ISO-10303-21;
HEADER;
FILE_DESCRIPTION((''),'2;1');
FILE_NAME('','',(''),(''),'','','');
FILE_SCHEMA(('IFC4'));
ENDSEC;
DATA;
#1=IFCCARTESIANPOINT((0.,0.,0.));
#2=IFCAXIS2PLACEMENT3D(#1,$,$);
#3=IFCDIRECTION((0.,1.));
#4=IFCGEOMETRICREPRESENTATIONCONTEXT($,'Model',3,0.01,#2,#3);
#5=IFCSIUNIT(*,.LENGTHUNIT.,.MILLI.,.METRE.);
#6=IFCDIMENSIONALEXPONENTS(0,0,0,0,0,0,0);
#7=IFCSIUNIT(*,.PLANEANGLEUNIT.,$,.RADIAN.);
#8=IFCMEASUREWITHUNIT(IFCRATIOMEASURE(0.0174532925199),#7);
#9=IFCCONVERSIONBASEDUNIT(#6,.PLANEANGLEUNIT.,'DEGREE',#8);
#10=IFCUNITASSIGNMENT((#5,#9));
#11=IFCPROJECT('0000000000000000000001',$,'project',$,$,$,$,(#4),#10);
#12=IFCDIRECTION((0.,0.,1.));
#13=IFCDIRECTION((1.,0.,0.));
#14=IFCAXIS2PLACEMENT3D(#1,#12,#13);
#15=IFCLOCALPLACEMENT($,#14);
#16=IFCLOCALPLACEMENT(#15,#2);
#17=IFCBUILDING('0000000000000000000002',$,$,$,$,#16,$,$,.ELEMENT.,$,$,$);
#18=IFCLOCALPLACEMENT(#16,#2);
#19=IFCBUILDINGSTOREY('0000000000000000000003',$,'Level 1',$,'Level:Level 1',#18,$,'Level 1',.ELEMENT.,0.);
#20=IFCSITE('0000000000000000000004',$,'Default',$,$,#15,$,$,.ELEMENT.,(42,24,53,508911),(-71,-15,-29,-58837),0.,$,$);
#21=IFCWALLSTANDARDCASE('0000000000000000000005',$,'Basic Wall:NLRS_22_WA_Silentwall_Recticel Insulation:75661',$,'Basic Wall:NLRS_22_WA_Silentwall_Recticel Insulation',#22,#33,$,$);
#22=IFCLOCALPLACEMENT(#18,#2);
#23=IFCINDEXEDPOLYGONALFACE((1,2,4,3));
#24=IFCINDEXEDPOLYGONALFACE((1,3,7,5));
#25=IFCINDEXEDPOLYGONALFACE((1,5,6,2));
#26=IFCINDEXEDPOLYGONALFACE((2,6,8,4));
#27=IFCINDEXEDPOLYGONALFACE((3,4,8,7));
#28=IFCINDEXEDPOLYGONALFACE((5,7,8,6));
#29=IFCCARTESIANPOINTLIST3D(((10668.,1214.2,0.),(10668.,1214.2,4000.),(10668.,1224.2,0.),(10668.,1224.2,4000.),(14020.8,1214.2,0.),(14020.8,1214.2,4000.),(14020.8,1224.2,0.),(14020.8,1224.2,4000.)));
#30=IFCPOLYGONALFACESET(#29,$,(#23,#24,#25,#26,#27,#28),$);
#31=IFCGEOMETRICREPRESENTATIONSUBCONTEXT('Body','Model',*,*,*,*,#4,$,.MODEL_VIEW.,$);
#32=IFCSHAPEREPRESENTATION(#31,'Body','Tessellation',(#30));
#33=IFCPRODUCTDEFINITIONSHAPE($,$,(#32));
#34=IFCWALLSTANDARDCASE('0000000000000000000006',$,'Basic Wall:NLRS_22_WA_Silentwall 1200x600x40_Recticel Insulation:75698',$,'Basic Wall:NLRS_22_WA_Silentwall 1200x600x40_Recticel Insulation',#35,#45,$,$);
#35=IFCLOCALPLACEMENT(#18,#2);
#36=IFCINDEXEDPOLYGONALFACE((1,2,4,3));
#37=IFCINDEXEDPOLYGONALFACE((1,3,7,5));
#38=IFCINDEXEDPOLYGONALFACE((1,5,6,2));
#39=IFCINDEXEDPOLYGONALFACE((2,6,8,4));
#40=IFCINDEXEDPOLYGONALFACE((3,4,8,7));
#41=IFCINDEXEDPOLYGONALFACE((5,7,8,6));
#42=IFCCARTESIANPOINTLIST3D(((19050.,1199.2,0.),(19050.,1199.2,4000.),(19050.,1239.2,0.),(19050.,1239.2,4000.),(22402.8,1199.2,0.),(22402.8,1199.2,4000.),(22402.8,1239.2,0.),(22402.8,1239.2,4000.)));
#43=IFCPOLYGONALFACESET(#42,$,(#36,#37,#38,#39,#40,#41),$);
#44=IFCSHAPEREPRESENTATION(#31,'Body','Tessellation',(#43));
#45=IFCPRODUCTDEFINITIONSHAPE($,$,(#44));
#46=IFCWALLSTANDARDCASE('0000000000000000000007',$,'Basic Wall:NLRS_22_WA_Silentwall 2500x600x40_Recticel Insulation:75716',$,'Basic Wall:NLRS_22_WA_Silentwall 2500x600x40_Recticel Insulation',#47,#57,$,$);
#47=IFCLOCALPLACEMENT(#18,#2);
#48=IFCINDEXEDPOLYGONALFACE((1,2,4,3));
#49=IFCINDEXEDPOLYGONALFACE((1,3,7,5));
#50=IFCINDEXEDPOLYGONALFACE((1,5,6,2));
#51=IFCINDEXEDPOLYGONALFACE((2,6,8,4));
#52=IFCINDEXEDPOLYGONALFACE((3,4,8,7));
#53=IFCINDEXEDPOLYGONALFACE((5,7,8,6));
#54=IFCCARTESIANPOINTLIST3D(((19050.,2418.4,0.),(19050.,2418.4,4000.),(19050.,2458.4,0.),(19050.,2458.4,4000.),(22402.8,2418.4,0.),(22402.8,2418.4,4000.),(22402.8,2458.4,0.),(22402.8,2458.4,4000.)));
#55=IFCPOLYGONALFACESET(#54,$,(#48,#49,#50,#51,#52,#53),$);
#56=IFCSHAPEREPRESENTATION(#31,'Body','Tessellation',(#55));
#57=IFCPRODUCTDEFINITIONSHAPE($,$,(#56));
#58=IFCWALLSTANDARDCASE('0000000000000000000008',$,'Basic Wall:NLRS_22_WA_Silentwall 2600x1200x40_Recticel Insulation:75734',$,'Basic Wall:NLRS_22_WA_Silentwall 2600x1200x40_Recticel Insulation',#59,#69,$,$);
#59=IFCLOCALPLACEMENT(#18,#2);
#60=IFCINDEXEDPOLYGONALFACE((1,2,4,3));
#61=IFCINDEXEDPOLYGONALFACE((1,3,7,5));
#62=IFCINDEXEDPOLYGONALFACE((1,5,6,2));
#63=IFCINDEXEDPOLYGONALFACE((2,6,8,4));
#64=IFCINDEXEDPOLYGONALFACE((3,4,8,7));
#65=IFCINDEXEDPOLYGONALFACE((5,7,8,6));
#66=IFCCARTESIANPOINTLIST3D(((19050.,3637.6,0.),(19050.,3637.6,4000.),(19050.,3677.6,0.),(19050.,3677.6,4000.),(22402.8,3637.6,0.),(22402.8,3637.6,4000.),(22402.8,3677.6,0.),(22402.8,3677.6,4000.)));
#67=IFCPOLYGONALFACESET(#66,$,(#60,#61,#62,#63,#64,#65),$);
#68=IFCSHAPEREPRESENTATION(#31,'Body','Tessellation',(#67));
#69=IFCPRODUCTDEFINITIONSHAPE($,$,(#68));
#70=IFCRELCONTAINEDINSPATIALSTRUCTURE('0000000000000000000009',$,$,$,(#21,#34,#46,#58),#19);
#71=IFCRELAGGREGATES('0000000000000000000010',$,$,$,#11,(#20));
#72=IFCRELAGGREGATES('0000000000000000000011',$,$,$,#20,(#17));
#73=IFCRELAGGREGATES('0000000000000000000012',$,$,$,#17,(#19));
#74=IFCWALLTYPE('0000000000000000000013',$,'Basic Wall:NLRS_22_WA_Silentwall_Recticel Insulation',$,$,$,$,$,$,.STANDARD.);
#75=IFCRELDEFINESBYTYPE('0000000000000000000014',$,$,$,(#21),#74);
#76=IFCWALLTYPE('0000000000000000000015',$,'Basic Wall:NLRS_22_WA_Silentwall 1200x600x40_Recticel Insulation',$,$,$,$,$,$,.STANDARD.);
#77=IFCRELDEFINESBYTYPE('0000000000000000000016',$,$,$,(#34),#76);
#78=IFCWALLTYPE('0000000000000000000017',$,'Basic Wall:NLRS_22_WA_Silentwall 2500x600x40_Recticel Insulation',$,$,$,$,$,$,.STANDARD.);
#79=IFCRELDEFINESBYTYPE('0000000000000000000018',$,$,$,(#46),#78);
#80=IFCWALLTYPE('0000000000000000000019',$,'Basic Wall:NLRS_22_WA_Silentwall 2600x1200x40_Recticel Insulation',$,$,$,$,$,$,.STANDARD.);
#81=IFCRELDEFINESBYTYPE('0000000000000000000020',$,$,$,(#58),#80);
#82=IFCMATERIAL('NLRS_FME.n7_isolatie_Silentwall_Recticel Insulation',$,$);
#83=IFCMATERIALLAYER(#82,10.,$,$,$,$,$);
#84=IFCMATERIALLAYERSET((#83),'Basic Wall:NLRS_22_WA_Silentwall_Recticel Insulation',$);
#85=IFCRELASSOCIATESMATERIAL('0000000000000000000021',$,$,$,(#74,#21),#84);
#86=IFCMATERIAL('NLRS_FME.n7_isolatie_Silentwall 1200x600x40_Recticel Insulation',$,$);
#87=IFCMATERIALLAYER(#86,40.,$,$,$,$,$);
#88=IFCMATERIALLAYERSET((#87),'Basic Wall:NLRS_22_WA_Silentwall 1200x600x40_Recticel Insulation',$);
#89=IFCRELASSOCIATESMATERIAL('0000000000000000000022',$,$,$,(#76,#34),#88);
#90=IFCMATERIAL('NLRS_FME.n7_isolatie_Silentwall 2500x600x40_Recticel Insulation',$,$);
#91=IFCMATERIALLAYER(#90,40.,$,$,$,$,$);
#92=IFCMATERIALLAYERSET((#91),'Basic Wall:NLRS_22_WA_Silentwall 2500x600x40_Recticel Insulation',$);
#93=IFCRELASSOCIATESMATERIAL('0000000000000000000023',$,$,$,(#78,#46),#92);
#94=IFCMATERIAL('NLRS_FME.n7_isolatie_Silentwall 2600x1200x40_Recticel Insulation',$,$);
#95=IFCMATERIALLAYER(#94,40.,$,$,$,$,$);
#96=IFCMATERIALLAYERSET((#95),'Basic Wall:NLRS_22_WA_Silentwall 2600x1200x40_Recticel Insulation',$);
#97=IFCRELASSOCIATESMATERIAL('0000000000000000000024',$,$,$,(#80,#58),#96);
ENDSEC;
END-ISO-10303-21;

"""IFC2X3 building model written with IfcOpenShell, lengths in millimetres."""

from ifc_helpers import new_model, entity, si_unit, converted_unit, direction, frame, origin, origin_with_axes, origin_2d_with_axis, place, context, subcontext, project, spatial, rectangle, extrude, material, layer, layer_set, layer_usage, type_object, element, save


model = new_model("IFC2X3")

# Units and contexts
model_context = context("Model", 3, precision=0.01, world=origin(), true_north=direction((0.0, 1.0)))
body_context = subcontext(model_context, "Body", "Model", "MODEL_VIEW")
ifc_project = project(units=[si_unit("LENGTHUNIT", "METRE", prefix="MILLI"), converted_unit("PLANEANGLEUNIT", "DEGREE", entity("IfcRatioMeasure", 0.0174532925199), si_unit("PLANEANGLEUNIT", "RADIAN"), dimensions=[0, 0, 0, 0, 0, 0, 0])], contexts=[model_context])

# Site, building, storey
site_placement = place(None, origin_with_axes())
site = spatial("IfcSite", under=ifc_project, at=site_placement, Name="Default", CompositionType="ELEMENT", RefLatitude=(42, 24, 53, 508911), RefLongitude=(-71, -15, -29, -58837), RefElevation=0.0)
building_placement = place(site_placement, origin())
building = spatial("IfcBuilding", under=site, at=building_placement, CompositionType="ELEMENT")
storey_placement = place(building_placement, origin())
storey = spatial("IfcBuildingStorey", under=building, at=storey_placement, Name="Level 1", ObjectType="Level:Level 1", LongName="Level 1", CompositionType="ELEMENT", Elevation=0.0)

# Walls
ifc_material_1 = material(Name="NLRS_FME.n7_isolatie_Silentwall_Recticel Insulation")
ifc_layer_1 = layer(ifc_material_1, 10.0)
ifc_layer_set_1 = layer_set([ifc_layer_1], Name="Basic Wall:NLRS_22_WA_Silentwall_Recticel Insulation")
ifc_layer_usage_1 = layer_usage(ifc_layer_set_1, "AXIS2", "NEGATIVE", 5.0)
wall_type_1 = type_object("IfcWallType", Name="Basic Wall:NLRS_22_WA_Silentwall_Recticel Insulation", PredefinedType="STANDARD", material=ifc_layer_set_1)
wall_1_placement = place(storey_placement, frame((10668.0, 1219.2, 0.0)))
element("IfcWallStandardCase", 1, at=wall_1_placement, inside=storey, type_object=wall_type_1, material=ifc_layer_usage_1, Name="Basic Wall:NLRS_22_WA_Silentwall_Recticel Insulation:75661", ObjectType="Basic Wall:NLRS_22_WA_Silentwall_Recticel Insulation", context=body_context, shape_type="SweptSolid", body=[
    extrude(rectangle(XDim=3352.8, YDim=10.0, at=origin_2d_with_axis()), frame((1676.4, 0.0, 0.0), x_axis=(-1.0, 0.0, 0.0)), (0.0, 0.0, 1.0), 4000.0),
])
ifc_material_2 = material(Name="NLRS_FME.n7_isolatie_Silentwall 1200x600x40_Recticel Insulation")
ifc_layer_2 = layer(ifc_material_2, 40.0)
ifc_layer_set_2 = layer_set([ifc_layer_2], Name="Basic Wall:NLRS_22_WA_Silentwall 1200x600x40_Recticel Insulation")
ifc_layer_usage_2 = layer_usage(ifc_layer_set_2, "AXIS2", "NEGATIVE", 20.0)
wall_type_2 = type_object("IfcWallType", Name="Basic Wall:NLRS_22_WA_Silentwall 1200x600x40_Recticel Insulation", PredefinedType="STANDARD", material=ifc_layer_set_2)
wall_2_placement = place(storey_placement, frame((19050.0, 1219.2, 0.0)))
element("IfcWallStandardCase", 2, at=wall_2_placement, inside=storey, type_object=wall_type_2, material=ifc_layer_usage_2, Name="Basic Wall:NLRS_22_WA_Silentwall 1200x600x40_Recticel Insulation:75698", ObjectType="Basic Wall:NLRS_22_WA_Silentwall 1200x600x40_Recticel Insulation", context=body_context, shape_type="SweptSolid", body=[
    extrude(rectangle(XDim=3352.8, YDim=40.0, at=origin_2d_with_axis()), frame((1676.4, 0.0, 0.0), x_axis=(-1.0, 0.0, 0.0)), (0.0, 0.0, 1.0), 4000.0),
])
ifc_material_3 = material(Name="NLRS_FME.n7_isolatie_Silentwall 2500x600x40_Recticel Insulation")
ifc_layer_3 = layer(ifc_material_3, 40.0)
ifc_layer_set_3 = layer_set([ifc_layer_3], Name="Basic Wall:NLRS_22_WA_Silentwall 2500x600x40_Recticel Insulation")
ifc_layer_usage_3 = layer_usage(ifc_layer_set_3, "AXIS2", "NEGATIVE", 20.0)
wall_type_3 = type_object("IfcWallType", Name="Basic Wall:NLRS_22_WA_Silentwall 2500x600x40_Recticel Insulation", PredefinedType="STANDARD", material=ifc_layer_set_3)
wall_3_placement = place(storey_placement, frame((19050.0, 2438.4, 0.0)))
element("IfcWallStandardCase", 3, at=wall_3_placement, inside=storey, type_object=wall_type_3, material=ifc_layer_usage_3, Name="Basic Wall:NLRS_22_WA_Silentwall 2500x600x40_Recticel Insulation:75716", ObjectType="Basic Wall:NLRS_22_WA_Silentwall 2500x600x40_Recticel Insulation", context=body_context, shape_type="SweptSolid", body=[
    extrude(rectangle(XDim=3352.8, YDim=40.0, at=origin_2d_with_axis()), frame((1676.4, 0.0, 0.0), x_axis=(-1.0, 0.0, 0.0)), (0.0, 0.0, 1.0), 4000.0),
])
ifc_material_4 = material(Name="NLRS_FME.n7_isolatie_Silentwall 2600x1200x40_Recticel Insulation")
ifc_layer_4 = layer(ifc_material_4, 40.0)
ifc_layer_set_4 = layer_set([ifc_layer_4], Name="Basic Wall:NLRS_22_WA_Silentwall 2600x1200x40_Recticel Insulation")
ifc_layer_usage_4 = layer_usage(ifc_layer_set_4, "AXIS2", "NEGATIVE", 20.0)
wall_type_4 = type_object("IfcWallType", Name="Basic Wall:NLRS_22_WA_Silentwall 2600x1200x40_Recticel Insulation", PredefinedType="STANDARD", material=ifc_layer_set_4)
wall_4_placement = place(storey_placement, frame((19050.0, 3657.6, 0.0)))
element("IfcWallStandardCase", 4, at=wall_4_placement, inside=storey, type_object=wall_type_4, material=ifc_layer_usage_4, Name="Basic Wall:NLRS_22_WA_Silentwall 2600x1200x40_Recticel Insulation:75734", ObjectType="Basic Wall:NLRS_22_WA_Silentwall 2600x1200x40_Recticel Insulation", context=body_context, shape_type="SweptSolid", body=[
    extrude(rectangle(XDim=3352.8, YDim=40.0, at=origin_2d_with_axis()), frame((1676.4, 0.0, 0.0), x_axis=(-1.0, 0.0, 0.0)), (0.0, 0.0, 1.0), 4000.0),
])

save(model, "model.ifc")
